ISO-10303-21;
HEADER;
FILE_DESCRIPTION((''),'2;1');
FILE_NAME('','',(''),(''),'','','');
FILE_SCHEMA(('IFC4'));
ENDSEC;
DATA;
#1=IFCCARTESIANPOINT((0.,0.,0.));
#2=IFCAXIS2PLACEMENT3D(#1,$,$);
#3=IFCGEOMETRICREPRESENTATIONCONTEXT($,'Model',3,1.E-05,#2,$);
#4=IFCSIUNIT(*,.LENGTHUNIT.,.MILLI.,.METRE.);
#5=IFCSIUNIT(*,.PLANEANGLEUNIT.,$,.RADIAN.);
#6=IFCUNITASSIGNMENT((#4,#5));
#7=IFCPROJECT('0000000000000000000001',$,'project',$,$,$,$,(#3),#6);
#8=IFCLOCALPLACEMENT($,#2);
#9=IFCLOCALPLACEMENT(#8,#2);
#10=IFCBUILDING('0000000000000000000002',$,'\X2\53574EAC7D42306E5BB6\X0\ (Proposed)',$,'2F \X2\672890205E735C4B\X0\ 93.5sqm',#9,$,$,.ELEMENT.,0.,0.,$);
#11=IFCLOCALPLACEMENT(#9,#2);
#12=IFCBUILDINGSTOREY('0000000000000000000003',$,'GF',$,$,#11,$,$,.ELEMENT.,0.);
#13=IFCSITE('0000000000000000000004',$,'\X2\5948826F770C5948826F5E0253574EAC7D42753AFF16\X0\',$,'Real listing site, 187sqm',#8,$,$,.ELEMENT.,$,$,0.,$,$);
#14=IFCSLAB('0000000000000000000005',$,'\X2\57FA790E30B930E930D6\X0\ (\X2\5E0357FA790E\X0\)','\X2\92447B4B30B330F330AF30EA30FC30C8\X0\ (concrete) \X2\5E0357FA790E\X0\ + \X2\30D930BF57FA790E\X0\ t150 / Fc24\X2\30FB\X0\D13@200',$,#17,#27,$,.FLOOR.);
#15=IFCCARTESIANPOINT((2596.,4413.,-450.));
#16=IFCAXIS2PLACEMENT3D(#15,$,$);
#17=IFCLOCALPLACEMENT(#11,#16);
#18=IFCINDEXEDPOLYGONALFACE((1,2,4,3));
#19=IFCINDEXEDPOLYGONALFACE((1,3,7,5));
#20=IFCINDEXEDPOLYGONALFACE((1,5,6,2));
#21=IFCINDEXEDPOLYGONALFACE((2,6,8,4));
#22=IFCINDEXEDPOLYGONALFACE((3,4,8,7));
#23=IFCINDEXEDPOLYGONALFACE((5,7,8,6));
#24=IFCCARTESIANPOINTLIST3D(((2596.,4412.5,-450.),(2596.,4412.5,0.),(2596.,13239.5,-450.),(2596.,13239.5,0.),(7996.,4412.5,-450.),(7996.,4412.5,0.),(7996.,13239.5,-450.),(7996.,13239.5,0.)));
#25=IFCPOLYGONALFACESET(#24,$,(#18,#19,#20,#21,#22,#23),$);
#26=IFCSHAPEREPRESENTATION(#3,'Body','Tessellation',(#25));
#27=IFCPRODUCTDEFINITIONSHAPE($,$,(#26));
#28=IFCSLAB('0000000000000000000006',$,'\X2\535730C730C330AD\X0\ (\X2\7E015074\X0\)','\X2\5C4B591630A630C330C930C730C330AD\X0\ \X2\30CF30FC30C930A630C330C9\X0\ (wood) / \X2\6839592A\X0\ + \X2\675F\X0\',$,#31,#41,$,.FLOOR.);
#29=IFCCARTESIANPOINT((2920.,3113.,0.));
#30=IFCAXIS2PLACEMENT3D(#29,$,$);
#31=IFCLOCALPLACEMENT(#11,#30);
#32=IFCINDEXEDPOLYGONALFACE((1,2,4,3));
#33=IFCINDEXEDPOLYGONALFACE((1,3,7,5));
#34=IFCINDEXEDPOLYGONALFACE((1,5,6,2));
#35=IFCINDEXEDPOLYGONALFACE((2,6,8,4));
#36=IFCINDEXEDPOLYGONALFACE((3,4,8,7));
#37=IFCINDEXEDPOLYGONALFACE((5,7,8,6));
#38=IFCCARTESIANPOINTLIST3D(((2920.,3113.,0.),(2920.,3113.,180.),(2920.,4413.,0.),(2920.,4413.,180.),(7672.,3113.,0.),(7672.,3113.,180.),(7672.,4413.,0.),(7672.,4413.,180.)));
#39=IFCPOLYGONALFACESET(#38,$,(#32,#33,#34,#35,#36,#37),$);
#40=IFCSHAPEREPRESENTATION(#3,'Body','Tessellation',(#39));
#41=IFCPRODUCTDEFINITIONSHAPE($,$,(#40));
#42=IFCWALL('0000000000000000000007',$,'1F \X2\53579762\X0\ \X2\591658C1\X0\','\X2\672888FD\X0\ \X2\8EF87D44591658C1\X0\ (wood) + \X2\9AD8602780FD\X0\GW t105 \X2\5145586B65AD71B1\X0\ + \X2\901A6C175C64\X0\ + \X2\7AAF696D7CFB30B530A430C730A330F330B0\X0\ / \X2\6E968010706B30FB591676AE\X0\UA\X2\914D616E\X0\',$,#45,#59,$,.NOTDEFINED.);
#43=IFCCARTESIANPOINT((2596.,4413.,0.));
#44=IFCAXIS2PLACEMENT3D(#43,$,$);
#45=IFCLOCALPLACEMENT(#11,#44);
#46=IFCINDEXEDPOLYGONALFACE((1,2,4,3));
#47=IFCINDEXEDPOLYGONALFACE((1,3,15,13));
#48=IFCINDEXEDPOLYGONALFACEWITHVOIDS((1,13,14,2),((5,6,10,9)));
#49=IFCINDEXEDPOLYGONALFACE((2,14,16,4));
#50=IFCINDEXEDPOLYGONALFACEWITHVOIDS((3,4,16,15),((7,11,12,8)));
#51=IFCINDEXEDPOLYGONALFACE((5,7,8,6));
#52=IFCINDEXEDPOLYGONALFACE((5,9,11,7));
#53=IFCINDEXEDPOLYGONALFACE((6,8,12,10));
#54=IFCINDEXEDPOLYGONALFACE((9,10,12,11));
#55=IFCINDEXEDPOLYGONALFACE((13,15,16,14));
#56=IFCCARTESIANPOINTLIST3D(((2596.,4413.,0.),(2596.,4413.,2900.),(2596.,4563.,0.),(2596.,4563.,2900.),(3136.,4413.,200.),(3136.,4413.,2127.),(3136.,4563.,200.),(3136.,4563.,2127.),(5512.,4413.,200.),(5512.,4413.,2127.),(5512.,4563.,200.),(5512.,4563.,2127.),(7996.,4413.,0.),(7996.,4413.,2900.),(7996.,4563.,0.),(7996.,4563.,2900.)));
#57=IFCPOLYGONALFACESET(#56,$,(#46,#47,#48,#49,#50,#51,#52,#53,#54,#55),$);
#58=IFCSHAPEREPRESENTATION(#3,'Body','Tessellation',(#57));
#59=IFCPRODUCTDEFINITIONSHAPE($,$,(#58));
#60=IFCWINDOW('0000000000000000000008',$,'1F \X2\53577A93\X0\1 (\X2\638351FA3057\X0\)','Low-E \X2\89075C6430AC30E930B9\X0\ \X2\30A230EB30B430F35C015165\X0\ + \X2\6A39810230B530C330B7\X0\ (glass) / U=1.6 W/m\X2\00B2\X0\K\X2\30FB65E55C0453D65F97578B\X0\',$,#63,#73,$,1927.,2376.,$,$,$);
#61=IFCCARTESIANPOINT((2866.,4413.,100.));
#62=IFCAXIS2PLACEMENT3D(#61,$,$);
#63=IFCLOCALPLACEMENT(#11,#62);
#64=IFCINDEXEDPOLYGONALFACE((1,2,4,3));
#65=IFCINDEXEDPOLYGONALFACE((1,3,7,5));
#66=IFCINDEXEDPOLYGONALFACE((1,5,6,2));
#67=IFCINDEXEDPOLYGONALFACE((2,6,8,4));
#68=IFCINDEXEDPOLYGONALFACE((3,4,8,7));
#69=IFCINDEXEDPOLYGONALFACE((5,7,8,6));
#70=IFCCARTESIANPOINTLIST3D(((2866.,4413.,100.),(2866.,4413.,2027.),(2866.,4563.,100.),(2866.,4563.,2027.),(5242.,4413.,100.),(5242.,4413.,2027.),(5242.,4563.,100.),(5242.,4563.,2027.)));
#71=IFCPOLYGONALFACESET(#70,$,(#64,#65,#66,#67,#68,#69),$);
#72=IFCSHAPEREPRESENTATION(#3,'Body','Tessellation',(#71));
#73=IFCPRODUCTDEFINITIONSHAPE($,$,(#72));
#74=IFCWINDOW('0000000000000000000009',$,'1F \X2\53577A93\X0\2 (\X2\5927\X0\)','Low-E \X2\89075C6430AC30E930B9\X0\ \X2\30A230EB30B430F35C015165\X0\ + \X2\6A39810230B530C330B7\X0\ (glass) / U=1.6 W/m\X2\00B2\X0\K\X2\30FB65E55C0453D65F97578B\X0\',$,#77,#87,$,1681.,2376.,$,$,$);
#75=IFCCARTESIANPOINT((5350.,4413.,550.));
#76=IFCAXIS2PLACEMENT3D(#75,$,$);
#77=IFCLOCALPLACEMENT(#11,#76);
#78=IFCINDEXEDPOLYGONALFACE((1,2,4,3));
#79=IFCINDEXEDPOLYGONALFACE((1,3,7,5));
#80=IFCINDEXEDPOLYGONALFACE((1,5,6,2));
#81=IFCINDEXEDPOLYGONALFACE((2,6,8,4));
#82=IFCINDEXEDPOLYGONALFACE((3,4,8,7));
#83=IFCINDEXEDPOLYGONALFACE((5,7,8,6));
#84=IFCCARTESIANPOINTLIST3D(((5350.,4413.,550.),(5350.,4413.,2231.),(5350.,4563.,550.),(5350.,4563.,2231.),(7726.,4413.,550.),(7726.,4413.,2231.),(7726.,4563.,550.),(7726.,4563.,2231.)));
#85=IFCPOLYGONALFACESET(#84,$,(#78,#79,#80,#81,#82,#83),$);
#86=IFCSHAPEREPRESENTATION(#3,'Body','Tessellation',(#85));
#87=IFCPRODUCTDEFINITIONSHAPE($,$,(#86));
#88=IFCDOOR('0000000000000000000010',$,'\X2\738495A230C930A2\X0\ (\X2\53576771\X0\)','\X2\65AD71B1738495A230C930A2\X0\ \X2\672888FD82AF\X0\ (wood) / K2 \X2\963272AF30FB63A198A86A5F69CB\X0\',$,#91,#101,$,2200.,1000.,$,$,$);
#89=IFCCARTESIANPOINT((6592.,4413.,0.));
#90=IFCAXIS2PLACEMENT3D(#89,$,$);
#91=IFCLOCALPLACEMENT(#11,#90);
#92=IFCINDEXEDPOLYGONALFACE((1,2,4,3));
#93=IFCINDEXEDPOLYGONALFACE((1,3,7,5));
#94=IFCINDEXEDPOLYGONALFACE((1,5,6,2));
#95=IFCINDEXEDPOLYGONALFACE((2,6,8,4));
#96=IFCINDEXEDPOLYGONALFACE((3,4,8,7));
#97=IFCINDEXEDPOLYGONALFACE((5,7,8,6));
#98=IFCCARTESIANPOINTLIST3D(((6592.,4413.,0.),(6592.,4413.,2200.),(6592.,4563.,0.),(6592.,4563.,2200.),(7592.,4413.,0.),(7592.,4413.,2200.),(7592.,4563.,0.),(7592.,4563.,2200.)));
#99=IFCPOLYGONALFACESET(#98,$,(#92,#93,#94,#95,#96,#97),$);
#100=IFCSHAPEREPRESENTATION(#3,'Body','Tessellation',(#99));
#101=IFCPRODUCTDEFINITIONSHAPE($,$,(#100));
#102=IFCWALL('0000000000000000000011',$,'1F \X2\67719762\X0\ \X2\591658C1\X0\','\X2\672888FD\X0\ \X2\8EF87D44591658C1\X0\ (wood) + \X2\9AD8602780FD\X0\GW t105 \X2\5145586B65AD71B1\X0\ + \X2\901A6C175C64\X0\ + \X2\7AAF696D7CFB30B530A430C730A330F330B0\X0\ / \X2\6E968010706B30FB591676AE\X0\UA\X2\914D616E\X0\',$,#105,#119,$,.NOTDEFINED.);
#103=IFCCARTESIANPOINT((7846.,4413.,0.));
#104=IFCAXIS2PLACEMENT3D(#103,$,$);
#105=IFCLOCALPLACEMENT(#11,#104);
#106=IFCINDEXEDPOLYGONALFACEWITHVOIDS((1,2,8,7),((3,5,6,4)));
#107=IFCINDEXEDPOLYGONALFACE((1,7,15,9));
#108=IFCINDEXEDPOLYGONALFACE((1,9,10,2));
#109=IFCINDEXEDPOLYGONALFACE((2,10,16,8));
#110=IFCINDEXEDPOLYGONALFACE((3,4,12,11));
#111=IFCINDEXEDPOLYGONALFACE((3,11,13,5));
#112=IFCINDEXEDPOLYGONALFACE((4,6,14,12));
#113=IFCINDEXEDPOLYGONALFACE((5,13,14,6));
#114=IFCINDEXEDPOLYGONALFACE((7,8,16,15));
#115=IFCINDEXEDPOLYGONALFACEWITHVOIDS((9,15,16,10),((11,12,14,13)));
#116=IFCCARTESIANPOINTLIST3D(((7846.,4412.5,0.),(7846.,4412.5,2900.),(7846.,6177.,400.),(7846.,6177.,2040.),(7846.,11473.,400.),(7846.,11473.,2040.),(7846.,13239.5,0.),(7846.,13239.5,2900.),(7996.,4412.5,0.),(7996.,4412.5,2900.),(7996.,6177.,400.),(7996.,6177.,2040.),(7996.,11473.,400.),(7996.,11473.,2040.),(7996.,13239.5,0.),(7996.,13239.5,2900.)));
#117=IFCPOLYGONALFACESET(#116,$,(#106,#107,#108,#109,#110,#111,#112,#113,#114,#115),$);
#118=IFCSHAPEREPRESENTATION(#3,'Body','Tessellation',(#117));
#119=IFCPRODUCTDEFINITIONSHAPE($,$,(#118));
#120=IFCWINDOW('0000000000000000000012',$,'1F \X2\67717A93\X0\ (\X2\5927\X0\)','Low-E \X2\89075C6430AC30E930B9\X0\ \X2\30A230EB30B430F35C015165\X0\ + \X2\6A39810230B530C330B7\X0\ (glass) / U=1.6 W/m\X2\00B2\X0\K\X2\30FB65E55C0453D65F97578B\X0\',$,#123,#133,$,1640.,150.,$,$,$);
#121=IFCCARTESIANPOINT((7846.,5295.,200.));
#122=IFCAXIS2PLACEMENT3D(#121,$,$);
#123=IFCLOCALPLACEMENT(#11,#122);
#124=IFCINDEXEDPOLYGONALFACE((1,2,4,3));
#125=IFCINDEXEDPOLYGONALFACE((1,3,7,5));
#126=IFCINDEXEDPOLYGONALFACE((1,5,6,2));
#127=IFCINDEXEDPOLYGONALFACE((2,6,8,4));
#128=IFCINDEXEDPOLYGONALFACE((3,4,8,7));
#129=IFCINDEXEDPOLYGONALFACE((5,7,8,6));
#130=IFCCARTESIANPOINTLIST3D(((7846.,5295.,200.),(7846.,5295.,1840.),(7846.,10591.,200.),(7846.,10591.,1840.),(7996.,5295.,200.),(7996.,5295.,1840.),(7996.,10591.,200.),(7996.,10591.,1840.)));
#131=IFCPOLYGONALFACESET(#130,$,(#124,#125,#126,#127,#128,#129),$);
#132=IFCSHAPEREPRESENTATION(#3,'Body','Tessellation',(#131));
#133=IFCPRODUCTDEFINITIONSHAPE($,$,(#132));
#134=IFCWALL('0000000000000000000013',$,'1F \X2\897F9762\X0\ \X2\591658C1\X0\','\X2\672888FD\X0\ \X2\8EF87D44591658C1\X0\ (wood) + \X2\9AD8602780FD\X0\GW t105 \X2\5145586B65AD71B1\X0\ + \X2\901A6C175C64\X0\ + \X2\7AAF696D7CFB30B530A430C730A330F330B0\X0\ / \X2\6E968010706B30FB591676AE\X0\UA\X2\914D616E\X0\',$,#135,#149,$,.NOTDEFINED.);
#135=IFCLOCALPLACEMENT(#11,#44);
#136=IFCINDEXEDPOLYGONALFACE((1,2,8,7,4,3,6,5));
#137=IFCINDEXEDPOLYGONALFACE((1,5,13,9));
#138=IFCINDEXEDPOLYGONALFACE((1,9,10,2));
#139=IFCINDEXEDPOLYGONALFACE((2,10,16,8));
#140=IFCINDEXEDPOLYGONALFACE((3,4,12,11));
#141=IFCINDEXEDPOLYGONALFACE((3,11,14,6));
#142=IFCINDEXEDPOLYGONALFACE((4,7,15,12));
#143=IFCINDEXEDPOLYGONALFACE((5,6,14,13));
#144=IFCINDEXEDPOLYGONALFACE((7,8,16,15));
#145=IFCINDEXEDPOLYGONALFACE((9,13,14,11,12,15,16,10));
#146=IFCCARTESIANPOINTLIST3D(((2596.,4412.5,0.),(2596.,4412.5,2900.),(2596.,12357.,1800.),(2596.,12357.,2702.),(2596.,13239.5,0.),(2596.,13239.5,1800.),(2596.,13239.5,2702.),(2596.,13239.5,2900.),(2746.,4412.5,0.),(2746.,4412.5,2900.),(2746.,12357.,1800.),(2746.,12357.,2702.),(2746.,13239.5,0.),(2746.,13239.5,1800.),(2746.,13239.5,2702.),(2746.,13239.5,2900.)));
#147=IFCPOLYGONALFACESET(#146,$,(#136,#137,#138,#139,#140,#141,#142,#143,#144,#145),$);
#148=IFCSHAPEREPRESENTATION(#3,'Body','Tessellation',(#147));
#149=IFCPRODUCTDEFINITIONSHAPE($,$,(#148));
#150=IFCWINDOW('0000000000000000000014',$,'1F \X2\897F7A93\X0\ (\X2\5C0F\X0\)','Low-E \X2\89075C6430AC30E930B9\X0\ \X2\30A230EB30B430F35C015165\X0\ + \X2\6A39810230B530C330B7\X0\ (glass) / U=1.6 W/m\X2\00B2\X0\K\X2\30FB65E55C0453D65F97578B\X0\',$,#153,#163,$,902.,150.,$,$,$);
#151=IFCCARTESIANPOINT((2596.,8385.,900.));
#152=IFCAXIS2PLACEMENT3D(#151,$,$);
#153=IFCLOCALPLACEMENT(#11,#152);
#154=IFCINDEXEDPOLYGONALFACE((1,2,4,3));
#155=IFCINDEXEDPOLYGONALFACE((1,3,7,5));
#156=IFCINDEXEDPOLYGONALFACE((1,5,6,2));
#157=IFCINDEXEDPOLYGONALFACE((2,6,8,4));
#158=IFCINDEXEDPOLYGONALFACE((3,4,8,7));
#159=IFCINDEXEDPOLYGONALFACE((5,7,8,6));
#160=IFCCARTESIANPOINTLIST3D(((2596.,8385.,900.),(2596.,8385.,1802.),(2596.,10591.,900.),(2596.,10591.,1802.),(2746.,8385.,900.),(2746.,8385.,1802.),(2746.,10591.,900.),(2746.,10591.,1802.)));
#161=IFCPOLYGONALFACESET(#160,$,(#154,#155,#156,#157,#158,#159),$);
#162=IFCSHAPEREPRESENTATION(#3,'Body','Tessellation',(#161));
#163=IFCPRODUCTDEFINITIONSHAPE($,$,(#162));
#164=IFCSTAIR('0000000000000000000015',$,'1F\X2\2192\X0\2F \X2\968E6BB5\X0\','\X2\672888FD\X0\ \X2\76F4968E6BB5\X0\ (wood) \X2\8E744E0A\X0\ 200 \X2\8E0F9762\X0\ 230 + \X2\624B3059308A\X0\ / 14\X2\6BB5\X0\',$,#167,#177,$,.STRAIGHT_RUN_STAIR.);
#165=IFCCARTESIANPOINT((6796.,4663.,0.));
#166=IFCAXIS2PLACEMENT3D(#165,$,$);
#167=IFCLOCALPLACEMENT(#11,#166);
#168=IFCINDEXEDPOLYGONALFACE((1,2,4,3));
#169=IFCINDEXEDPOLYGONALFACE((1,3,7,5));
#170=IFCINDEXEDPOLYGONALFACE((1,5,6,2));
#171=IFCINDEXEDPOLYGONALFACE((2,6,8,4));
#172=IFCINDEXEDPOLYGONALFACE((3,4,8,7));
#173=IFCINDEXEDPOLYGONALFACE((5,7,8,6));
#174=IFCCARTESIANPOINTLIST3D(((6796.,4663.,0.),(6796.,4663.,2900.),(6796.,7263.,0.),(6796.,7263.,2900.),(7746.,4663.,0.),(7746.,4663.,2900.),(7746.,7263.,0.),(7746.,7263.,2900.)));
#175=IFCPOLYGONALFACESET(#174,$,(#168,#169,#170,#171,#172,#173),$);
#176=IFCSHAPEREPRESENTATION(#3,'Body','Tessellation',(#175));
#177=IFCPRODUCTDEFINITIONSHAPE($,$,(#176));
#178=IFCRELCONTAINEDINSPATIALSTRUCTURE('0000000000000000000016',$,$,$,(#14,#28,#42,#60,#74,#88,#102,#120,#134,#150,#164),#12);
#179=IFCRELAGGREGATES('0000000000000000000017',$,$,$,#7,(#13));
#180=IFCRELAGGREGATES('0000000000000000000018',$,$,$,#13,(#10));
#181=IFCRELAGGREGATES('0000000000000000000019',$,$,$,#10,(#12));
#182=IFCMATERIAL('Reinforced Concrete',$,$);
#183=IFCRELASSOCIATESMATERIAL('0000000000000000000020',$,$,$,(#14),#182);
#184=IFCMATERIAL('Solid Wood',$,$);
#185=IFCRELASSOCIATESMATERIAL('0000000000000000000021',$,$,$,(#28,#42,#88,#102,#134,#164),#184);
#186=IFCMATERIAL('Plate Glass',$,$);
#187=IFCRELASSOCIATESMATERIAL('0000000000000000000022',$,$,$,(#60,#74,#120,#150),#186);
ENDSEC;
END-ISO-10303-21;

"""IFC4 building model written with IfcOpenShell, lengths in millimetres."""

from ifc_helpers import new_model, si_unit, frame, frame_2d, origin, place, context, project, spatial, rectangle, extrude, material, element, fill, save


model = new_model("IFC4")

# Units and contexts
model_context = context("Model", 3, precision=1e-05, world=origin())
ifc_project = project(units=[si_unit("LENGTHUNIT", "METRE", prefix="MILLI"), si_unit("PLANEANGLEUNIT", "RADIAN")], contexts=[model_context])

# Site, building, storey
site_placement = place(None, origin())
site = spatial("IfcSite", under=ifc_project, at=site_placement, Name="奈良県奈良市南京終町６", ObjectType="Real listing site, 187sqm", CompositionType="ELEMENT", RefElevation=0.0)
building_placement = place(site_placement, origin())
building = spatial("IfcBuilding", under=site, at=building_placement, Name="南京終の家 (Proposed)", ObjectType="2F 木造平屋 93.5sqm", CompositionType="ELEMENT", ElevationOfRefHeight=0.0, ElevationOfTerrain=0.0)
storey_placement = place(building_placement, origin())
storey = spatial("IfcBuildingStorey", under=building, at=storey_placement, Name="GF", CompositionType="ELEMENT", Elevation=0.0)

# Slabs
ifc_material_1 = material(Name="Reinforced Concrete")
slab_1_placement = place(storey_placement, frame((2596.0, 4413.0, -450.0)))
element("IfcSlab", 1, at=slab_1_placement, inside=storey, material=ifc_material_1, Name="基礎スラブ (布基礎)", Description="鉄筋コンクリート (concrete) 布基礎 + ベタ基礎 t150 / Fc24・D13@200", PredefinedType="FLOOR", context=model_context, shape_type="SweptSolid", body=[
    extrude(rectangle(XDim=5400.0, YDim=8827.0, at=frame_2d((2700.0, 4413.0))), frame((2596.0, 4413.0, -450.0)), (0.0, 0.0, 1.0), 450.0),
])
ifc_material_2 = material(Name="Solid Wood")
slab_2_placement = place(storey_placement, frame((2920.0, 3113.0, 0.0)))
element("IfcSlab", 2, at=slab_2_placement, inside=storey, material=ifc_material_2, Name="南デッキ (縁側)", Description="屋外ウッドデッキ ハードウッド (wood) / 根太 + 束", PredefinedType="FLOOR", context=model_context, shape_type="SweptSolid", body=[
    extrude(rectangle(XDim=4752.0, YDim=1300.0, at=frame_2d((2376.0, 650.0))), frame((2920.0, 3113.0, 0.0)), (0.0, 0.0, 1.0), 180.0),
])

# Wall, openings, windows, door
wall_1_placement = place(storey_placement, frame((2596.0, 4413.0, 0.0)))
wall_1 = element("IfcWall", 3, at=wall_1_placement, inside=storey, material=ifc_material_2, Name="1F 南面 外壁", Description="木製 軸組外壁 (wood) + 高性能GW t105 充填断熱 + 通気層 + 窯業系サイディング / 準耐火・外皮UA配慮", PredefinedType="NOTDEFINED", context=model_context, shape_type="SweptSolid", body=[
    extrude(rectangle(XDim=5400.0, YDim=150.0, at=frame_2d((2700.0, 75.0))), frame((2596.0, 4413.0, 0.0)), (0.0, 0.0, 1.0), 2900.0),
])
opening_1_placement = place(storey_placement, frame((2866.0, 4413.0, 100.0)))
opening_1 = element("IfcOpeningElement", 4, at=opening_1_placement, cuts=wall_1, PredefinedType="NOTDEFINED", context=model_context, shape_type="SweptSolid", body=[
    extrude(rectangle(XDim=2376.0, YDim=150.0, at=frame_2d((1188.0, 75.0))), frame((2866.0, 4413.0, 100.0)), (0.0, 0.0, 1.0), 1927.0),
])
opening_2_placement = place(storey_placement, frame((5350.0, 4413.0, 550.0)))
opening_2 = element("IfcOpeningElement", 5, at=opening_2_placement, cuts=wall_1, PredefinedType="NOTDEFINED", context=model_context, shape_type="SweptSolid", body=[
    extrude(rectangle(XDim=2376.0, YDim=150.0, at=frame_2d((1188.0, 75.0))), frame((5350.0, 4413.0, 550.0)), (0.0, 0.0, 1.0), 1681.0),
])
opening_3_placement = place(storey_placement, frame((6592.0, 4413.0, 0.0)))
opening_3 = element("IfcOpeningElement", 6, at=opening_3_placement, cuts=wall_1, PredefinedType="NOTDEFINED", context=model_context, shape_type="SweptSolid", body=[
    extrude(rectangle(XDim=1000.0, YDim=150.0, at=frame_2d((500.0, 75.0))), frame((6592.0, 4413.0, 0.0)), (0.0, 0.0, 1.0), 2200.0),
])
ifc_material_3 = material(Name="Plate Glass")
window_1_placement = place(storey_placement, frame((2866.0, 4413.0, 100.0)))
window_1 = element("IfcWindow", 7, at=window_1_placement, inside=storey, material=ifc_material_3, Name="1F 南窓1 (掃出し)", Description="Low-E 複層ガラス アルゴン封入 + 樹脂サッシ (glass) / U=1.6 W/m²K・日射取得型", OverallHeight=1927.0, OverallWidth=2376.0, context=model_context, shape_type="SweptSolid", body=[
    extrude(rectangle(XDim=2376.0, YDim=150.0, at=frame_2d((1188.0, 75.0))), frame((2866.0, 4413.0, 100.0)), (0.0, 0.0, 1.0), 1927.0),
])
fill(opening_1, window_1)
window_2_placement = place(storey_placement, frame((5350.0, 4413.0, 550.0)))
window_2 = element("IfcWindow", 8, at=window_2_placement, inside=storey, material=ifc_material_3, Name="1F 南窓2 (大)", Description="Low-E 複層ガラス アルゴン封入 + 樹脂サッシ (glass) / U=1.6 W/m²K・日射取得型", OverallHeight=1681.0, OverallWidth=2376.0, context=model_context, shape_type="SweptSolid", body=[
    extrude(rectangle(XDim=2376.0, YDim=150.0, at=frame_2d((1188.0, 75.0))), frame((5350.0, 4413.0, 550.0)), (0.0, 0.0, 1.0), 1681.0),
])
fill(opening_2, window_2)
door_placement = place(storey_placement, frame((6592.0, 4413.0, 0.0)))
door = element("IfcDoor", 9, at=door_placement, inside=storey, material=ifc_material_2, Name="玄関ドア (南東)", Description="断熱玄関ドア 木製芯 (wood) / K2 防犯・採風機構", OverallHeight=2200.0, OverallWidth=1000.0, context=model_context, shape_type="SweptSolid", body=[
    extrude(rectangle(XDim=1000.0, YDim=150.0, at=frame_2d((500.0, 75.0))), frame((6592.0, 4413.0, 0.0)), (0.0, 0.0, 1.0), 2200.0),
])
fill(opening_3, door)

# Walls, openings, windows
wall_2_placement = place(storey_placement, frame((7846.0, 4413.0, 0.0)))
wall_2 = element("IfcWall", 10, at=wall_2_placement, inside=storey, material=ifc_material_2, Name="1F 東面 外壁", Description="木製 軸組外壁 (wood) + 高性能GW t105 充填断熱 + 通気層 + 窯業系サイディング / 準耐火・外皮UA配慮", PredefinedType="NOTDEFINED", context=model_context, shape_type="SweptSolid", body=[
    extrude(rectangle(XDim=150.0, YDim=8827.0, at=frame_2d((75.0, 4413.0))), frame((7846.0, 4413.0, 0.0)), (0.0, 0.0, 1.0), 2900.0),
])
opening_4_placement = place(storey_placement, frame((7846.0, 5295.0, 200.0)))
opening_4 = element("IfcOpeningElement", 11, at=opening_4_placement, cuts=wall_2, PredefinedType="NOTDEFINED", context=model_context, shape_type="SweptSolid", body=[
    extrude(rectangle(XDim=150.0, YDim=5296.0, at=frame_2d((75.0, 2648.0))), frame((7846.0, 5295.0, 200.0)), (0.0, 0.0, 1.0), 1640.0),
])
window_3_placement = place(storey_placement, frame((7846.0, 5295.0, 200.0)))
window_3 = element("IfcWindow", 12, at=window_3_placement, inside=storey, material=ifc_material_3, Name="1F 東窓 (大)", Description="Low-E 複層ガラス アルゴン封入 + 樹脂サッシ (glass) / U=1.6 W/m²K・日射取得型", OverallHeight=1640.0, OverallWidth=150.0, context=model_context, shape_type="SweptSolid", body=[
    extrude(rectangle(XDim=150.0, YDim=5296.0, at=frame_2d((75.0, 2648.0))), frame((7846.0, 5295.0, 200.0)), (0.0, 0.0, 1.0), 1640.0),
])
fill(opening_4, window_3)
wall_3_placement = place(storey_placement, frame((2596.0, 4413.0, 0.0)))
wall_3 = element("IfcWall", 13, at=wall_3_placement, inside=storey, material=ifc_material_2, Name="1F 西面 外壁", Description="木製 軸組外壁 (wood) + 高性能GW t105 充填断熱 + 通気層 + 窯業系サイディング / 準耐火・外皮UA配慮", PredefinedType="NOTDEFINED", context=model_context, shape_type="SweptSolid", body=[
    extrude(rectangle(XDim=150.0, YDim=8827.0, at=frame_2d((75.0, 4413.0))), frame((2596.0, 4413.0, 0.0)), (0.0, 0.0, 1.0), 2900.0),
])
opening_5_placement = place(storey_placement, frame((2596.0, 8385.0, 900.0)))
opening_5 = element("IfcOpeningElement", 14, at=opening_5_placement, cuts=wall_3, PredefinedType="NOTDEFINED", context=model_context, shape_type="SweptSolid", body=[
    extrude(rectangle(XDim=150.0, YDim=2206.0, at=frame_2d((75.0, 1103.0))), frame((2596.0, 8385.0, 900.0)), (0.0, 0.0, 1.0), 902.0),
])
window_4_placement = place(storey_placement, frame((2596.0, 8385.0, 900.0)))
window_4 = element("IfcWindow", 15, at=window_4_placement, inside=storey, material=ifc_material_3, Name="1F 西窓 (小)", Description="Low-E 複層ガラス アルゴン封入 + 樹脂サッシ (glass) / U=1.6 W/m²K・日射取得型", OverallHeight=902.0, OverallWidth=150.0, context=model_context, shape_type="SweptSolid", body=[
    extrude(rectangle(XDim=150.0, YDim=2206.0, at=frame_2d((75.0, 1103.0))), frame((2596.0, 8385.0, 900.0)), (0.0, 0.0, 1.0), 902.0),
])
fill(opening_5, window_4)

# Stair
stair_placement = place(storey_placement, frame((6796.0, 4663.0, 0.0)))
element("IfcStair", 16, at=stair_placement, inside=storey, material=ifc_material_2, Name="1F→2F 階段", Description="木製 直階段 (wood) 蹴上 200 踏面 230 + 手すり / 14段", PredefinedType="STRAIGHT_RUN_STAIR", context=model_context, shape_type="SweptSolid", body=[
    extrude(rectangle(XDim=950.0, YDim=2600.0, at=frame_2d((475.0, 1300.0))), frame((6796.0, 4663.0, 0.0)), (0.0, 0.0, 1.0), 2900.0),
])

save(model, "model.ifc")
